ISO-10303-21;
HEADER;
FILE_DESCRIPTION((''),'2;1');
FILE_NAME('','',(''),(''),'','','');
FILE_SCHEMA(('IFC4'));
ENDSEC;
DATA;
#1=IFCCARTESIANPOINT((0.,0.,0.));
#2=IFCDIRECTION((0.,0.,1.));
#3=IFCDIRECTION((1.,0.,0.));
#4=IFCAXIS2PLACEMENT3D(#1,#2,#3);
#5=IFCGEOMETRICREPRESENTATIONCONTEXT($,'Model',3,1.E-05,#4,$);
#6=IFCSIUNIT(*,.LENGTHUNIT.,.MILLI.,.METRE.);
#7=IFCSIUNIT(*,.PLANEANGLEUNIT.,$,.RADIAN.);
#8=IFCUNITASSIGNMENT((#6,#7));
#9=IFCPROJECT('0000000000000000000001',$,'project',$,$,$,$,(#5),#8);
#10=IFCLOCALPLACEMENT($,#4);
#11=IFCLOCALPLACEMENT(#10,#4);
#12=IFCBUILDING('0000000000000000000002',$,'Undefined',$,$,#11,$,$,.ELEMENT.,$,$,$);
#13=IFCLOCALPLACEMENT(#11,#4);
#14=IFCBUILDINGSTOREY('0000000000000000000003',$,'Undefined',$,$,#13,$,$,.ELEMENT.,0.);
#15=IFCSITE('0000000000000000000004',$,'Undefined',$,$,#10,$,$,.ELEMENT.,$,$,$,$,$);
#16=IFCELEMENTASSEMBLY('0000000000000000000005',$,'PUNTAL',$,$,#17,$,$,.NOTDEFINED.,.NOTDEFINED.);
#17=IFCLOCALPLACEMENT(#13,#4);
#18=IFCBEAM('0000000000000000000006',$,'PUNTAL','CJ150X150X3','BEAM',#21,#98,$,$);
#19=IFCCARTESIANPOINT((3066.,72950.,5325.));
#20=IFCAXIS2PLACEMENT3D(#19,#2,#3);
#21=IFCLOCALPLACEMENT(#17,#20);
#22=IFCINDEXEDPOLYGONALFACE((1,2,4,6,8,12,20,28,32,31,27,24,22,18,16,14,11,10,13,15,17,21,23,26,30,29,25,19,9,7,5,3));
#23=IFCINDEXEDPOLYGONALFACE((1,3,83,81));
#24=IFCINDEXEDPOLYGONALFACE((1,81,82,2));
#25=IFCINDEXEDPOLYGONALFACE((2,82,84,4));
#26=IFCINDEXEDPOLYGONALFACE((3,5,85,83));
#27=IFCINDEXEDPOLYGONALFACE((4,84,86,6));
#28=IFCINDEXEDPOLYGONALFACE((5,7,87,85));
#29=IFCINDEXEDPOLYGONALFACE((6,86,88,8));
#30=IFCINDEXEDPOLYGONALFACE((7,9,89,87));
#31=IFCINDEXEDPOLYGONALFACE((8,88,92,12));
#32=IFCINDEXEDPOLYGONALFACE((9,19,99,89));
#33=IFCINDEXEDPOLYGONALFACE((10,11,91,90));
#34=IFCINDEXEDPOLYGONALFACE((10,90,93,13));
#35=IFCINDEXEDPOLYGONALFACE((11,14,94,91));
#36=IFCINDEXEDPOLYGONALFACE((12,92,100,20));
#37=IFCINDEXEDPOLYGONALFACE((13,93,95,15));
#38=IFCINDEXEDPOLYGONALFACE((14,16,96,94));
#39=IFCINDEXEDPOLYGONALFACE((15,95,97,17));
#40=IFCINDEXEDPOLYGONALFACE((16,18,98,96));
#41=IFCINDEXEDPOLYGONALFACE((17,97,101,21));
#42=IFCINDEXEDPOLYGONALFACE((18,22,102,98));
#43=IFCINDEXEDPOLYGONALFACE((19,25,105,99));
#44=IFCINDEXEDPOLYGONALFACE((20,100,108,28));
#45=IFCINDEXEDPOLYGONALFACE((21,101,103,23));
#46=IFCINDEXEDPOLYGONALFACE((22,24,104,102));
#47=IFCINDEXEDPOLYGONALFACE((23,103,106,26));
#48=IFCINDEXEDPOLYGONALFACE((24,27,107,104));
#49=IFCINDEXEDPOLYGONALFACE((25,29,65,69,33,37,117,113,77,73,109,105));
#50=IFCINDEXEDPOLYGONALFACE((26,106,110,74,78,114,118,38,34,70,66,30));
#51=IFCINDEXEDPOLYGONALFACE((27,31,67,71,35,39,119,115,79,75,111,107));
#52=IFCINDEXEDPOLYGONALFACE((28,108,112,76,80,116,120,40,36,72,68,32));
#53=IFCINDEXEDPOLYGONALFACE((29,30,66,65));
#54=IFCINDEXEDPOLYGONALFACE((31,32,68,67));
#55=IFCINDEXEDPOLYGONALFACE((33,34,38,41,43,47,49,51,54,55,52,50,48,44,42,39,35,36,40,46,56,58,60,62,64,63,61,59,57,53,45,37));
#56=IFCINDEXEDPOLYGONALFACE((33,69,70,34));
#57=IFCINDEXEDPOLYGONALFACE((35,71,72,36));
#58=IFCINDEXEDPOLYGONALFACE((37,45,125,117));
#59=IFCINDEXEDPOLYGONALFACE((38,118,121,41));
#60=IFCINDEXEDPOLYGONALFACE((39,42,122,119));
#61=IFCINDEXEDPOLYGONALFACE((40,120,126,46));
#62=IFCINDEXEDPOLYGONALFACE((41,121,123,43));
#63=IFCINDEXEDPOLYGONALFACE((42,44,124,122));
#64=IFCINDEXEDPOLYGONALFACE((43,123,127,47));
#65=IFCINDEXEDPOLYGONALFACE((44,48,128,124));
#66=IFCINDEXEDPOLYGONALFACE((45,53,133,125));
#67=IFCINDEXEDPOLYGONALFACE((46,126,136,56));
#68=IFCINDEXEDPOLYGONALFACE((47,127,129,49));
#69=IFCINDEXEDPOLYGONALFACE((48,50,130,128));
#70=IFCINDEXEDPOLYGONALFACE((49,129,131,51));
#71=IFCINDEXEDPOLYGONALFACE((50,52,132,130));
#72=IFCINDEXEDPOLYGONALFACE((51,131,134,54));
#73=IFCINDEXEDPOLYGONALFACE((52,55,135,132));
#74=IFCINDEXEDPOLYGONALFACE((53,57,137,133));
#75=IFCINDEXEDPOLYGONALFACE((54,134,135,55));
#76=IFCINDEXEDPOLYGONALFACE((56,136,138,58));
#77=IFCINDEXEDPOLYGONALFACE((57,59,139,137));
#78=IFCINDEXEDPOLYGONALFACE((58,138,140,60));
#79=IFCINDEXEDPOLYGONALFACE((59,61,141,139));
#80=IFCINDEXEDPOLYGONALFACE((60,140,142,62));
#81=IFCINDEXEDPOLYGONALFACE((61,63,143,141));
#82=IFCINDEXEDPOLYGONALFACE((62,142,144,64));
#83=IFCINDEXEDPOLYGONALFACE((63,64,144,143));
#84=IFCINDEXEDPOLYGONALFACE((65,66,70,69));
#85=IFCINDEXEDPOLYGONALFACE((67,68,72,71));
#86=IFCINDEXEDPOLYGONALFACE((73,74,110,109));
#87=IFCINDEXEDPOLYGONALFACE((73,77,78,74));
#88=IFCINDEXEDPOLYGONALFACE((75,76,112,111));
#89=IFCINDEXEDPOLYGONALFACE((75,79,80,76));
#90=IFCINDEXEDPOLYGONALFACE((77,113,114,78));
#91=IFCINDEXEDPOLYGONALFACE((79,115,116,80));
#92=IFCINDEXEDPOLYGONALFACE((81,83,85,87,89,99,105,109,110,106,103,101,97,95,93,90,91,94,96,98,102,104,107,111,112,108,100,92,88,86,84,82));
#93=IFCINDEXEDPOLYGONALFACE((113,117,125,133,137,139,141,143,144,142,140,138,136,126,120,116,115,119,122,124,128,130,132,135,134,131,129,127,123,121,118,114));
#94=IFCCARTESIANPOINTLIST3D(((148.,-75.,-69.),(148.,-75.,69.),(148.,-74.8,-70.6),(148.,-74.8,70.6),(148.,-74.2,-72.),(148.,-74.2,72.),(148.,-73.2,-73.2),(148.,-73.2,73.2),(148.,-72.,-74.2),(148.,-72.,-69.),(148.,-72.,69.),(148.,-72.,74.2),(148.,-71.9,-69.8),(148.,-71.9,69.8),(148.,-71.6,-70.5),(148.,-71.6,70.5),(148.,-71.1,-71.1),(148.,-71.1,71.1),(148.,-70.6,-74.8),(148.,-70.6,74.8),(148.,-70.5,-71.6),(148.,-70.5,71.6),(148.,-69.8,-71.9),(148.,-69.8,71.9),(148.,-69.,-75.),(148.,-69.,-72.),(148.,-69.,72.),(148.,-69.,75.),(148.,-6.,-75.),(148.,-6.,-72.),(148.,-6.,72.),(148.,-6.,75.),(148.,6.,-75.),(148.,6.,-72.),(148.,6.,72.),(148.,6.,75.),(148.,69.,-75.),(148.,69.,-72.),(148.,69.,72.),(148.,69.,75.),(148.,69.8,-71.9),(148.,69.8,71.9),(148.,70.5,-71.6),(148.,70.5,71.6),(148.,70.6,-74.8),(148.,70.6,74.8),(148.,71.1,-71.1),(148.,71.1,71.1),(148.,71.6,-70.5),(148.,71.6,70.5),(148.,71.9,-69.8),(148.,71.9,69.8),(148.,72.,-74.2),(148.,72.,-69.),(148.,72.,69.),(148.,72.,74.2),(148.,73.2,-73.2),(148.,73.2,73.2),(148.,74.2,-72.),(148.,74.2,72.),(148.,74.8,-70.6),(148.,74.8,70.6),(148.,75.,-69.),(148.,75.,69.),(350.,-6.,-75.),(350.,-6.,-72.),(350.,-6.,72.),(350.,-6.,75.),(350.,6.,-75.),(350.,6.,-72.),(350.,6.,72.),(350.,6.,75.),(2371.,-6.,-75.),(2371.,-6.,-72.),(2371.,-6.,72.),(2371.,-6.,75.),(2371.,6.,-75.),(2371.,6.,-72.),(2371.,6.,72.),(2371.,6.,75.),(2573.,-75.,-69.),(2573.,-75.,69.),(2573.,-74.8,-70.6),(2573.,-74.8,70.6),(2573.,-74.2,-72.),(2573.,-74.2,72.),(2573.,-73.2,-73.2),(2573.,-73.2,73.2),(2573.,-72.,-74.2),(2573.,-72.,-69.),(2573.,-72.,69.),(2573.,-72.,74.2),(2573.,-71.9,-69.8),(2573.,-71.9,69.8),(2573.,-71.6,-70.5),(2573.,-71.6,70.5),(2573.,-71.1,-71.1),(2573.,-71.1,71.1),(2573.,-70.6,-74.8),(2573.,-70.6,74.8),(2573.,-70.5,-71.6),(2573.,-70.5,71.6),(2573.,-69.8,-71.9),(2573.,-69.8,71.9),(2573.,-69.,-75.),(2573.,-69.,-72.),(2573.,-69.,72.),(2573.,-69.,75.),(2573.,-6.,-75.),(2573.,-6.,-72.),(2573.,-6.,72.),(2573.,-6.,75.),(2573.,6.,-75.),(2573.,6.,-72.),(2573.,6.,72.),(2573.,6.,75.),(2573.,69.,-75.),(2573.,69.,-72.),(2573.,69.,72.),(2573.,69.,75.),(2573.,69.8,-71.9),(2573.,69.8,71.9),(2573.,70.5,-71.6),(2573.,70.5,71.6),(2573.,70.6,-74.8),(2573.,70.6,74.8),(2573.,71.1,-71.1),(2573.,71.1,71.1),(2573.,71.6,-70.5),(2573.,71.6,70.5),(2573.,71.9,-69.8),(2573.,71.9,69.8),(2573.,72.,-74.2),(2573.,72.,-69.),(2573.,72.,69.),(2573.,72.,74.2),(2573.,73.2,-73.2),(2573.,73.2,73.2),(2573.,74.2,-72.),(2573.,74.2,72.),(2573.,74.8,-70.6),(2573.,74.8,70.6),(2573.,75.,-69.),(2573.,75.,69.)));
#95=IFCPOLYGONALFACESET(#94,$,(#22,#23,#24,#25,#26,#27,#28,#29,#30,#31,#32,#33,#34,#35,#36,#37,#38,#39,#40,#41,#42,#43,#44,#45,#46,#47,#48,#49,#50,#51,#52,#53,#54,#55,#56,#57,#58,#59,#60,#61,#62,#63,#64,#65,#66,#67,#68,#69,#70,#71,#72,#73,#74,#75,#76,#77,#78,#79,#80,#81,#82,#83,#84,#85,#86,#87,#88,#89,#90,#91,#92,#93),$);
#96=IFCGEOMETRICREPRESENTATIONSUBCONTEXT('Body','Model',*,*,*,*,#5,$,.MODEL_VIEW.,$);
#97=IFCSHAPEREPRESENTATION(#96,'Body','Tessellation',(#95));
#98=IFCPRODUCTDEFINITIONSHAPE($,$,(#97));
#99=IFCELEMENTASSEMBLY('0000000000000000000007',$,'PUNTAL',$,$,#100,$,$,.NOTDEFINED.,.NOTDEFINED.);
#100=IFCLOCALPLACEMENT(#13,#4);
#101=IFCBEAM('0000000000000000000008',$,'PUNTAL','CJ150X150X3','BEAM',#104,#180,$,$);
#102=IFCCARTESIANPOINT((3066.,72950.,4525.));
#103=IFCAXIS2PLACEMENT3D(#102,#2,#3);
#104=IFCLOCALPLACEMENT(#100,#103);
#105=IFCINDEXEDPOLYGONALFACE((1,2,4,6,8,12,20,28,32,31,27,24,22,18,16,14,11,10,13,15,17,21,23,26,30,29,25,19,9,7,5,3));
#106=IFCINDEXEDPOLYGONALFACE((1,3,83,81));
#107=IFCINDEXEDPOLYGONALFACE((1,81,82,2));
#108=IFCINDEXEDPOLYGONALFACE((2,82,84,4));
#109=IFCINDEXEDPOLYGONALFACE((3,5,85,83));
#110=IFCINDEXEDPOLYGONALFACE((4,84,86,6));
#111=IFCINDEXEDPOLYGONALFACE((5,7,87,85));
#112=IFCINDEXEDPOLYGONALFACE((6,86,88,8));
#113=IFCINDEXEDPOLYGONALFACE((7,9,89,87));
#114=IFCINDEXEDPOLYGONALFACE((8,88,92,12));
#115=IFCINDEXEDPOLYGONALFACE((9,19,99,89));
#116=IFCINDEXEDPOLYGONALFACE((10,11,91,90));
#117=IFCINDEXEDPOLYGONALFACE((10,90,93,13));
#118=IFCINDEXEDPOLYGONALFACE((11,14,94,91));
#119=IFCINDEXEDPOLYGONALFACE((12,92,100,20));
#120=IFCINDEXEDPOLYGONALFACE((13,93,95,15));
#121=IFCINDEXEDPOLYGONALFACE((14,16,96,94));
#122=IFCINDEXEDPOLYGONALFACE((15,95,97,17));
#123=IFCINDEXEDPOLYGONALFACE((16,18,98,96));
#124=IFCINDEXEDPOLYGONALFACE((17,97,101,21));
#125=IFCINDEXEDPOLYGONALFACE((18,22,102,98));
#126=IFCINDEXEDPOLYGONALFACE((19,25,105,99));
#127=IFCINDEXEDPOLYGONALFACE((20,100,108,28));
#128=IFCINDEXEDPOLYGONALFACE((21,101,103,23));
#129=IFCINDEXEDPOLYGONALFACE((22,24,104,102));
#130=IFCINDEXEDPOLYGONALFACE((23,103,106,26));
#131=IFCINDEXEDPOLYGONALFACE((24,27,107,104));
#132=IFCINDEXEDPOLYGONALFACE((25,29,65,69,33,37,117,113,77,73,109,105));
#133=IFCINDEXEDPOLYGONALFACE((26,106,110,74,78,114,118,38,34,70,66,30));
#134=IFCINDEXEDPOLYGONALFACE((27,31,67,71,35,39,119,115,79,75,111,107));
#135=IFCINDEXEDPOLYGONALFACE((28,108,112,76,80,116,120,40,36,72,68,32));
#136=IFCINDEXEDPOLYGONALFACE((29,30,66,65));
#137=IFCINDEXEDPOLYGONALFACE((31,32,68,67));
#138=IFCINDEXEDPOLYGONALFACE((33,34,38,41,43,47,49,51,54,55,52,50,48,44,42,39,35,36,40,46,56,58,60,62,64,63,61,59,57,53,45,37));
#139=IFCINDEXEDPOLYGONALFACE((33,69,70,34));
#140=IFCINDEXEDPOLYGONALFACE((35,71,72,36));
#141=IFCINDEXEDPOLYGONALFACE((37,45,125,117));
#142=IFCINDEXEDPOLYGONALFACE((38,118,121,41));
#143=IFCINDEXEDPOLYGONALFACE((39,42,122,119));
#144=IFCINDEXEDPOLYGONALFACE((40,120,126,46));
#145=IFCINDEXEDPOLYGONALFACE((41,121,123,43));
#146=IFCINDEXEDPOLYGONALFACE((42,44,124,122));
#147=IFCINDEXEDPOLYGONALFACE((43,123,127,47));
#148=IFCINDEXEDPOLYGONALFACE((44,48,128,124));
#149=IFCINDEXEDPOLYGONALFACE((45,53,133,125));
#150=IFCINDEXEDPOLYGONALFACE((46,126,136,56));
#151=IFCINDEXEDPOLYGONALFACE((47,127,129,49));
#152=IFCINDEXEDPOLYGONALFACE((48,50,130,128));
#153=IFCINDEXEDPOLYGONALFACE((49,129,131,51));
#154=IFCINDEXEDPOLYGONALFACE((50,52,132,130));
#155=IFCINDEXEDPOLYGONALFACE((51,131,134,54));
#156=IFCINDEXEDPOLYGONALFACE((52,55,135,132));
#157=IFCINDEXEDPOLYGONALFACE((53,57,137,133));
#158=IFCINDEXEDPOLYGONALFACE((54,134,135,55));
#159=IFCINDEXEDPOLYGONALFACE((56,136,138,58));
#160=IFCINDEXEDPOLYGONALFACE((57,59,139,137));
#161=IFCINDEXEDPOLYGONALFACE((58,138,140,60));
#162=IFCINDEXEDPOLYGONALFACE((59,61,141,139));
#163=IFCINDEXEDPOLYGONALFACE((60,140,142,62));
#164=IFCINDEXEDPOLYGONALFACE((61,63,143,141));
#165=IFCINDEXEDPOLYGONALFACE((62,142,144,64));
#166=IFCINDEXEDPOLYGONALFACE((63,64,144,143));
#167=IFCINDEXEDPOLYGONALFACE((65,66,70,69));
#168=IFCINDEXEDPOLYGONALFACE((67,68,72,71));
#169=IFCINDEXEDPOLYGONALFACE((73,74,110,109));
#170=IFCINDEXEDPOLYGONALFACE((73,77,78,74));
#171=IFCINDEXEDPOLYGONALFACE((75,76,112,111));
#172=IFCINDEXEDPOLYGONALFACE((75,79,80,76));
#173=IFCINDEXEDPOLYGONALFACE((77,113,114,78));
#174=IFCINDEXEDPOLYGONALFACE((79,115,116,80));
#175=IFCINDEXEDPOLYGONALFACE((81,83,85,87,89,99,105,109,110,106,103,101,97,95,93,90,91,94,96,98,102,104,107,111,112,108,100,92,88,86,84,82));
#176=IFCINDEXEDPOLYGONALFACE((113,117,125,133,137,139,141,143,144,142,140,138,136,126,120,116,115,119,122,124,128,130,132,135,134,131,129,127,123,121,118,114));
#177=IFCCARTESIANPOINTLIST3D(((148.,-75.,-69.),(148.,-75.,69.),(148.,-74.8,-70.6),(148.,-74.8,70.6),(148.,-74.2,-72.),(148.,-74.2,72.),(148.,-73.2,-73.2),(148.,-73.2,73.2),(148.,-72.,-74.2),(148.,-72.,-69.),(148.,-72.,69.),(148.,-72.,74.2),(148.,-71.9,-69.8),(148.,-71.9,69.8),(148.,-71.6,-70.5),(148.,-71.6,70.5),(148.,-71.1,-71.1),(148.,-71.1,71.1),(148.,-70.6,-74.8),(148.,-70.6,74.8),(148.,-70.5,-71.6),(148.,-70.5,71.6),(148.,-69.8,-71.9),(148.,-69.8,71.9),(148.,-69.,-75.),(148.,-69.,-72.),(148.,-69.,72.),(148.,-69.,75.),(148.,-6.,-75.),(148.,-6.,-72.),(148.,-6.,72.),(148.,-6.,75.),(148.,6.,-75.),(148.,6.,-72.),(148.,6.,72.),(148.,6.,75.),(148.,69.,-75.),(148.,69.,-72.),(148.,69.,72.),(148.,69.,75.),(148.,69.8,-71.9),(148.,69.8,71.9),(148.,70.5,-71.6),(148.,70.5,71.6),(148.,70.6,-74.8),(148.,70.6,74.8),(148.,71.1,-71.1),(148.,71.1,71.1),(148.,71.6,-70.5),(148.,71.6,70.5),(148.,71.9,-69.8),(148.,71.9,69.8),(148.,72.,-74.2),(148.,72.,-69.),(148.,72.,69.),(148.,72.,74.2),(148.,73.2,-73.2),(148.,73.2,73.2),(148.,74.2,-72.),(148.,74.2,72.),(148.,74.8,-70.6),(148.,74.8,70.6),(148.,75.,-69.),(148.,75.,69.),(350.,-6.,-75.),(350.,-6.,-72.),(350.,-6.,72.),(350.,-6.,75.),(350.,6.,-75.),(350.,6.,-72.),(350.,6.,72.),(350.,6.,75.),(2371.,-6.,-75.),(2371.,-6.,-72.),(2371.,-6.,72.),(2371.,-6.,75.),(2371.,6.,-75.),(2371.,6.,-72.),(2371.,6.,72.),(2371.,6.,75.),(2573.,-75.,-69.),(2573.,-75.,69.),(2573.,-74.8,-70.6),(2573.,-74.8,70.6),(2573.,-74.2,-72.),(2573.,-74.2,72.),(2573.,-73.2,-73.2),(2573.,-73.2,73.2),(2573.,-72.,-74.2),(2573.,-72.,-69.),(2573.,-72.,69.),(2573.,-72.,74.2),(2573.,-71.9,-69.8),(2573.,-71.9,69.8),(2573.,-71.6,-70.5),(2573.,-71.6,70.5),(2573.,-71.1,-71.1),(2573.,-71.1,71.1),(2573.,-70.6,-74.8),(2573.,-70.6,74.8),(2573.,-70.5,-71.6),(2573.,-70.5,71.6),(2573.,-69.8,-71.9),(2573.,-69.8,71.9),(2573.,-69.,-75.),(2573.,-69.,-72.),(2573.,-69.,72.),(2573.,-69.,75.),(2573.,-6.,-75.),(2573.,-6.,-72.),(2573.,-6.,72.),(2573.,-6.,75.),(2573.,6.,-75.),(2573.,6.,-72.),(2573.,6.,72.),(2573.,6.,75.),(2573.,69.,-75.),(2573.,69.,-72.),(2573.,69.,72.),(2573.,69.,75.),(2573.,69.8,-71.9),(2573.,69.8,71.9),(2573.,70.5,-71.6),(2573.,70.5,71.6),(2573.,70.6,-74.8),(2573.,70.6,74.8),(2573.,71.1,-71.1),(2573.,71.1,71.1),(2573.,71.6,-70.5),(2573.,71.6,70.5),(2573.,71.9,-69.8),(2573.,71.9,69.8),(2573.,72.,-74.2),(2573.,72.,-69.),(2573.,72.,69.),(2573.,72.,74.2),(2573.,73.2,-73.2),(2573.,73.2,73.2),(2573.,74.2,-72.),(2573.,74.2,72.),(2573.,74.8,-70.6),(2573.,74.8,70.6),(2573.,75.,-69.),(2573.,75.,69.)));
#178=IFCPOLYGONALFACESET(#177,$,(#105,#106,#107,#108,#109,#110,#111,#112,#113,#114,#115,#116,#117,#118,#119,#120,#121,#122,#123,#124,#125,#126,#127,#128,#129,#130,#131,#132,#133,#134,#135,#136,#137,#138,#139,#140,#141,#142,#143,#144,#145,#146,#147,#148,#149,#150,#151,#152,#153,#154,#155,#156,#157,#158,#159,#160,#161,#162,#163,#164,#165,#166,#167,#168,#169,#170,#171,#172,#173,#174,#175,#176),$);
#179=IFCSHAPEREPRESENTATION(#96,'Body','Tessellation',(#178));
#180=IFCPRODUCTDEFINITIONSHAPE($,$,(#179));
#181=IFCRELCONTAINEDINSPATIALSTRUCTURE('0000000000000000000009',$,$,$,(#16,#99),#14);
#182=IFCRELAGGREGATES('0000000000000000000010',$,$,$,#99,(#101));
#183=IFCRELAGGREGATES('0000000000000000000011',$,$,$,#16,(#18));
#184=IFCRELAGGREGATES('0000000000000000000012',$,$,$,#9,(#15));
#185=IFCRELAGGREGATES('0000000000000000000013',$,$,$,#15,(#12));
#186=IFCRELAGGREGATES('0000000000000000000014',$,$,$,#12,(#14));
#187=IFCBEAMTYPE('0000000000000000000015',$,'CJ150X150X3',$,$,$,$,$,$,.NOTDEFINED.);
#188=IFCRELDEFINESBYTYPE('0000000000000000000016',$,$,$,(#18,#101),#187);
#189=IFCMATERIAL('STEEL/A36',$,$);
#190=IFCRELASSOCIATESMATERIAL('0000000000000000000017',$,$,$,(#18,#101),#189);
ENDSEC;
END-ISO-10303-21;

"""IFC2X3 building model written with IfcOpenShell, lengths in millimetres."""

from ifc_helpers import new_model, si_unit, frame, origin_with_axes, origin_2d_with_axis, place, context, subcontext, project, spatial, rectangle, hollow_rectangle, extrude, boolean, halfspace, material, type_object, element, aggregate, save


model = new_model("IFC2X3")

# Units and contexts
model_context = context("Model", 3, precision=1e-05, world=origin_with_axes())
body_context = subcontext(model_context, "Body", "Model", "MODEL_VIEW")
ifc_project = project(units=[si_unit("LENGTHUNIT", "METRE", prefix="MILLI"), si_unit("PLANEANGLEUNIT", "RADIAN")], contexts=[model_context])

# Site, building, storey
site_placement = place(None, origin_with_axes())
site = spatial("IfcSite", under=ifc_project, at=site_placement, Name="Undefined", CompositionType="ELEMENT")
building_placement = place(site_placement, origin_with_axes())
building = spatial("IfcBuilding", under=site, at=building_placement, Name="Undefined", CompositionType="ELEMENT")
storey_placement = place(building_placement, origin_with_axes())
storey = spatial("IfcBuildingStorey", under=building, at=storey_placement, Name="Undefined", CompositionType="ELEMENT", Elevation=0.0)

# Shared definitions
ifc_material_1 = material(Name="STEEL/A36")

# Element assemblies, beams
assembly_1_placement = place(storey_placement, origin_with_axes())
assembly_1 = element("IfcElementAssembly", 1, at=assembly_1_placement, inside=storey, Name="PUNTAL", AssemblyPlace="NOTDEFINED", PredefinedType="NOTDEFINED")
beam_type_1 = type_object("IfcBeamType", Name="CJ150X150X3", PredefinedType="NOTDEFINED")
beam_1_placement = place(assembly_1_placement, frame((3066.0, 72950.0, 5325.0), z_axis=(0.0, 0.0, 1.0), x_axis=(1.0, 0.0, 0.0)))
beam_1 = element("IfcBeam", 2, at=beam_1_placement, type_object=beam_type_1, material=ifc_material_1, Name="PUNTAL", Description="CJ150X150X3", ObjectType="BEAM", context=body_context, shape_type="CSG", body=[
    boolean("DIFFERENCE", boolean("DIFFERENCE", boolean("DIFFERENCE", boolean("DIFFERENCE", extrude(hollow_rectangle(XDim=150.0, YDim=150.0, WallThickness=3.0, InnerFilletRadius=3.0, OuterFilletRadius=6.0, at=origin_2d_with_axis()), frame((2721.0, 0.0, 0.0), z_axis=(-1.0, 0.0, 0.0), x_axis=(0.0, -1.0, 0.0)), (0.0, 0.0, 1.0), 2721.0), extrude(rectangle(XDim=12.0, YDim=154.0, at=origin_2d_with_axis()), frame((2371.0, 0.0, 0.0), z_axis=(1.0, 0.0, 0.0), x_axis=(0.0, -1.0, 0.0)), (0.0, 0.0, 1.0), 214.0)), extrude(rectangle(XDim=12.0, YDim=154.0, at=origin_2d_with_axis()), frame((350.0, 0.0, 0.0), z_axis=(-1.0, 0.0, 0.0), x_axis=(0.0, 1.0, 0.0)), (0.0, 0.0, 1.0), 214.0)), halfspace(frame((2573.0, 15.0, 0.0), z_axis=(-1.0, 0.0, 0.0), x_axis=(0.0, -1.0, 0.0)), True)), halfspace(frame((148.0, 15.0, 0.0), z_axis=(1.0, 0.0, 0.0), x_axis=(0.0, 0.0, -1.0)), True)),
])
assembly_2_placement = place(storey_placement, origin_with_axes())
assembly_2 = element("IfcElementAssembly", 3, at=assembly_2_placement, inside=storey, Name="PUNTAL", AssemblyPlace="NOTDEFINED", PredefinedType="NOTDEFINED")
beam_2_placement = place(assembly_2_placement, frame((3066.0, 72950.0, 4525.0), z_axis=(0.0, 0.0, 1.0), x_axis=(1.0, 0.0, 0.0)))
beam_2 = element("IfcBeam", 4, at=beam_2_placement, type_object=beam_type_1, material=ifc_material_1, Name="PUNTAL", Description="CJ150X150X3", ObjectType="BEAM", context=body_context, shape_type="CSG", body=[
    boolean("DIFFERENCE", boolean("DIFFERENCE", boolean("DIFFERENCE", boolean("DIFFERENCE", extrude(hollow_rectangle(XDim=150.0, YDim=150.0, WallThickness=3.0, InnerFilletRadius=3.0, OuterFilletRadius=6.0, at=origin_2d_with_axis()), frame((2721.0, 0.0, 0.0), z_axis=(-1.0, 0.0, 0.0), x_axis=(0.0, -1.0, 0.0)), (0.0, 0.0, 1.0), 2721.0), extrude(rectangle(XDim=12.0, YDim=154.0, at=origin_2d_with_axis()), frame((2371.0, 0.0, 0.0), z_axis=(1.0, 0.0, 0.0), x_axis=(0.0, 1.0, 0.0)), (0.0, 0.0, 1.0), 225.0)), extrude(rectangle(XDim=12.0, YDim=154.0, at=origin_2d_with_axis()), frame((350.0, 0.0, 0.0), z_axis=(-1.0, 0.0, 0.0), x_axis=(0.0, -1.0, 0.0)), (0.0, 0.0, 1.0), 225.0)), halfspace(frame((2573.0, -15.0, 0.0), z_axis=(-1.0, 0.0, 0.0), x_axis=(0.0, 1.0, 0.0)), True)), halfspace(frame((148.0, -15.0, 0.0), z_axis=(1.0, 0.0, 0.0), x_axis=(0.0, 0.0, 1.0)), True)),
])

aggregate(assembly_2, [beam_2])
aggregate(assembly_1, [beam_1])

save(model, "model.ifc")
